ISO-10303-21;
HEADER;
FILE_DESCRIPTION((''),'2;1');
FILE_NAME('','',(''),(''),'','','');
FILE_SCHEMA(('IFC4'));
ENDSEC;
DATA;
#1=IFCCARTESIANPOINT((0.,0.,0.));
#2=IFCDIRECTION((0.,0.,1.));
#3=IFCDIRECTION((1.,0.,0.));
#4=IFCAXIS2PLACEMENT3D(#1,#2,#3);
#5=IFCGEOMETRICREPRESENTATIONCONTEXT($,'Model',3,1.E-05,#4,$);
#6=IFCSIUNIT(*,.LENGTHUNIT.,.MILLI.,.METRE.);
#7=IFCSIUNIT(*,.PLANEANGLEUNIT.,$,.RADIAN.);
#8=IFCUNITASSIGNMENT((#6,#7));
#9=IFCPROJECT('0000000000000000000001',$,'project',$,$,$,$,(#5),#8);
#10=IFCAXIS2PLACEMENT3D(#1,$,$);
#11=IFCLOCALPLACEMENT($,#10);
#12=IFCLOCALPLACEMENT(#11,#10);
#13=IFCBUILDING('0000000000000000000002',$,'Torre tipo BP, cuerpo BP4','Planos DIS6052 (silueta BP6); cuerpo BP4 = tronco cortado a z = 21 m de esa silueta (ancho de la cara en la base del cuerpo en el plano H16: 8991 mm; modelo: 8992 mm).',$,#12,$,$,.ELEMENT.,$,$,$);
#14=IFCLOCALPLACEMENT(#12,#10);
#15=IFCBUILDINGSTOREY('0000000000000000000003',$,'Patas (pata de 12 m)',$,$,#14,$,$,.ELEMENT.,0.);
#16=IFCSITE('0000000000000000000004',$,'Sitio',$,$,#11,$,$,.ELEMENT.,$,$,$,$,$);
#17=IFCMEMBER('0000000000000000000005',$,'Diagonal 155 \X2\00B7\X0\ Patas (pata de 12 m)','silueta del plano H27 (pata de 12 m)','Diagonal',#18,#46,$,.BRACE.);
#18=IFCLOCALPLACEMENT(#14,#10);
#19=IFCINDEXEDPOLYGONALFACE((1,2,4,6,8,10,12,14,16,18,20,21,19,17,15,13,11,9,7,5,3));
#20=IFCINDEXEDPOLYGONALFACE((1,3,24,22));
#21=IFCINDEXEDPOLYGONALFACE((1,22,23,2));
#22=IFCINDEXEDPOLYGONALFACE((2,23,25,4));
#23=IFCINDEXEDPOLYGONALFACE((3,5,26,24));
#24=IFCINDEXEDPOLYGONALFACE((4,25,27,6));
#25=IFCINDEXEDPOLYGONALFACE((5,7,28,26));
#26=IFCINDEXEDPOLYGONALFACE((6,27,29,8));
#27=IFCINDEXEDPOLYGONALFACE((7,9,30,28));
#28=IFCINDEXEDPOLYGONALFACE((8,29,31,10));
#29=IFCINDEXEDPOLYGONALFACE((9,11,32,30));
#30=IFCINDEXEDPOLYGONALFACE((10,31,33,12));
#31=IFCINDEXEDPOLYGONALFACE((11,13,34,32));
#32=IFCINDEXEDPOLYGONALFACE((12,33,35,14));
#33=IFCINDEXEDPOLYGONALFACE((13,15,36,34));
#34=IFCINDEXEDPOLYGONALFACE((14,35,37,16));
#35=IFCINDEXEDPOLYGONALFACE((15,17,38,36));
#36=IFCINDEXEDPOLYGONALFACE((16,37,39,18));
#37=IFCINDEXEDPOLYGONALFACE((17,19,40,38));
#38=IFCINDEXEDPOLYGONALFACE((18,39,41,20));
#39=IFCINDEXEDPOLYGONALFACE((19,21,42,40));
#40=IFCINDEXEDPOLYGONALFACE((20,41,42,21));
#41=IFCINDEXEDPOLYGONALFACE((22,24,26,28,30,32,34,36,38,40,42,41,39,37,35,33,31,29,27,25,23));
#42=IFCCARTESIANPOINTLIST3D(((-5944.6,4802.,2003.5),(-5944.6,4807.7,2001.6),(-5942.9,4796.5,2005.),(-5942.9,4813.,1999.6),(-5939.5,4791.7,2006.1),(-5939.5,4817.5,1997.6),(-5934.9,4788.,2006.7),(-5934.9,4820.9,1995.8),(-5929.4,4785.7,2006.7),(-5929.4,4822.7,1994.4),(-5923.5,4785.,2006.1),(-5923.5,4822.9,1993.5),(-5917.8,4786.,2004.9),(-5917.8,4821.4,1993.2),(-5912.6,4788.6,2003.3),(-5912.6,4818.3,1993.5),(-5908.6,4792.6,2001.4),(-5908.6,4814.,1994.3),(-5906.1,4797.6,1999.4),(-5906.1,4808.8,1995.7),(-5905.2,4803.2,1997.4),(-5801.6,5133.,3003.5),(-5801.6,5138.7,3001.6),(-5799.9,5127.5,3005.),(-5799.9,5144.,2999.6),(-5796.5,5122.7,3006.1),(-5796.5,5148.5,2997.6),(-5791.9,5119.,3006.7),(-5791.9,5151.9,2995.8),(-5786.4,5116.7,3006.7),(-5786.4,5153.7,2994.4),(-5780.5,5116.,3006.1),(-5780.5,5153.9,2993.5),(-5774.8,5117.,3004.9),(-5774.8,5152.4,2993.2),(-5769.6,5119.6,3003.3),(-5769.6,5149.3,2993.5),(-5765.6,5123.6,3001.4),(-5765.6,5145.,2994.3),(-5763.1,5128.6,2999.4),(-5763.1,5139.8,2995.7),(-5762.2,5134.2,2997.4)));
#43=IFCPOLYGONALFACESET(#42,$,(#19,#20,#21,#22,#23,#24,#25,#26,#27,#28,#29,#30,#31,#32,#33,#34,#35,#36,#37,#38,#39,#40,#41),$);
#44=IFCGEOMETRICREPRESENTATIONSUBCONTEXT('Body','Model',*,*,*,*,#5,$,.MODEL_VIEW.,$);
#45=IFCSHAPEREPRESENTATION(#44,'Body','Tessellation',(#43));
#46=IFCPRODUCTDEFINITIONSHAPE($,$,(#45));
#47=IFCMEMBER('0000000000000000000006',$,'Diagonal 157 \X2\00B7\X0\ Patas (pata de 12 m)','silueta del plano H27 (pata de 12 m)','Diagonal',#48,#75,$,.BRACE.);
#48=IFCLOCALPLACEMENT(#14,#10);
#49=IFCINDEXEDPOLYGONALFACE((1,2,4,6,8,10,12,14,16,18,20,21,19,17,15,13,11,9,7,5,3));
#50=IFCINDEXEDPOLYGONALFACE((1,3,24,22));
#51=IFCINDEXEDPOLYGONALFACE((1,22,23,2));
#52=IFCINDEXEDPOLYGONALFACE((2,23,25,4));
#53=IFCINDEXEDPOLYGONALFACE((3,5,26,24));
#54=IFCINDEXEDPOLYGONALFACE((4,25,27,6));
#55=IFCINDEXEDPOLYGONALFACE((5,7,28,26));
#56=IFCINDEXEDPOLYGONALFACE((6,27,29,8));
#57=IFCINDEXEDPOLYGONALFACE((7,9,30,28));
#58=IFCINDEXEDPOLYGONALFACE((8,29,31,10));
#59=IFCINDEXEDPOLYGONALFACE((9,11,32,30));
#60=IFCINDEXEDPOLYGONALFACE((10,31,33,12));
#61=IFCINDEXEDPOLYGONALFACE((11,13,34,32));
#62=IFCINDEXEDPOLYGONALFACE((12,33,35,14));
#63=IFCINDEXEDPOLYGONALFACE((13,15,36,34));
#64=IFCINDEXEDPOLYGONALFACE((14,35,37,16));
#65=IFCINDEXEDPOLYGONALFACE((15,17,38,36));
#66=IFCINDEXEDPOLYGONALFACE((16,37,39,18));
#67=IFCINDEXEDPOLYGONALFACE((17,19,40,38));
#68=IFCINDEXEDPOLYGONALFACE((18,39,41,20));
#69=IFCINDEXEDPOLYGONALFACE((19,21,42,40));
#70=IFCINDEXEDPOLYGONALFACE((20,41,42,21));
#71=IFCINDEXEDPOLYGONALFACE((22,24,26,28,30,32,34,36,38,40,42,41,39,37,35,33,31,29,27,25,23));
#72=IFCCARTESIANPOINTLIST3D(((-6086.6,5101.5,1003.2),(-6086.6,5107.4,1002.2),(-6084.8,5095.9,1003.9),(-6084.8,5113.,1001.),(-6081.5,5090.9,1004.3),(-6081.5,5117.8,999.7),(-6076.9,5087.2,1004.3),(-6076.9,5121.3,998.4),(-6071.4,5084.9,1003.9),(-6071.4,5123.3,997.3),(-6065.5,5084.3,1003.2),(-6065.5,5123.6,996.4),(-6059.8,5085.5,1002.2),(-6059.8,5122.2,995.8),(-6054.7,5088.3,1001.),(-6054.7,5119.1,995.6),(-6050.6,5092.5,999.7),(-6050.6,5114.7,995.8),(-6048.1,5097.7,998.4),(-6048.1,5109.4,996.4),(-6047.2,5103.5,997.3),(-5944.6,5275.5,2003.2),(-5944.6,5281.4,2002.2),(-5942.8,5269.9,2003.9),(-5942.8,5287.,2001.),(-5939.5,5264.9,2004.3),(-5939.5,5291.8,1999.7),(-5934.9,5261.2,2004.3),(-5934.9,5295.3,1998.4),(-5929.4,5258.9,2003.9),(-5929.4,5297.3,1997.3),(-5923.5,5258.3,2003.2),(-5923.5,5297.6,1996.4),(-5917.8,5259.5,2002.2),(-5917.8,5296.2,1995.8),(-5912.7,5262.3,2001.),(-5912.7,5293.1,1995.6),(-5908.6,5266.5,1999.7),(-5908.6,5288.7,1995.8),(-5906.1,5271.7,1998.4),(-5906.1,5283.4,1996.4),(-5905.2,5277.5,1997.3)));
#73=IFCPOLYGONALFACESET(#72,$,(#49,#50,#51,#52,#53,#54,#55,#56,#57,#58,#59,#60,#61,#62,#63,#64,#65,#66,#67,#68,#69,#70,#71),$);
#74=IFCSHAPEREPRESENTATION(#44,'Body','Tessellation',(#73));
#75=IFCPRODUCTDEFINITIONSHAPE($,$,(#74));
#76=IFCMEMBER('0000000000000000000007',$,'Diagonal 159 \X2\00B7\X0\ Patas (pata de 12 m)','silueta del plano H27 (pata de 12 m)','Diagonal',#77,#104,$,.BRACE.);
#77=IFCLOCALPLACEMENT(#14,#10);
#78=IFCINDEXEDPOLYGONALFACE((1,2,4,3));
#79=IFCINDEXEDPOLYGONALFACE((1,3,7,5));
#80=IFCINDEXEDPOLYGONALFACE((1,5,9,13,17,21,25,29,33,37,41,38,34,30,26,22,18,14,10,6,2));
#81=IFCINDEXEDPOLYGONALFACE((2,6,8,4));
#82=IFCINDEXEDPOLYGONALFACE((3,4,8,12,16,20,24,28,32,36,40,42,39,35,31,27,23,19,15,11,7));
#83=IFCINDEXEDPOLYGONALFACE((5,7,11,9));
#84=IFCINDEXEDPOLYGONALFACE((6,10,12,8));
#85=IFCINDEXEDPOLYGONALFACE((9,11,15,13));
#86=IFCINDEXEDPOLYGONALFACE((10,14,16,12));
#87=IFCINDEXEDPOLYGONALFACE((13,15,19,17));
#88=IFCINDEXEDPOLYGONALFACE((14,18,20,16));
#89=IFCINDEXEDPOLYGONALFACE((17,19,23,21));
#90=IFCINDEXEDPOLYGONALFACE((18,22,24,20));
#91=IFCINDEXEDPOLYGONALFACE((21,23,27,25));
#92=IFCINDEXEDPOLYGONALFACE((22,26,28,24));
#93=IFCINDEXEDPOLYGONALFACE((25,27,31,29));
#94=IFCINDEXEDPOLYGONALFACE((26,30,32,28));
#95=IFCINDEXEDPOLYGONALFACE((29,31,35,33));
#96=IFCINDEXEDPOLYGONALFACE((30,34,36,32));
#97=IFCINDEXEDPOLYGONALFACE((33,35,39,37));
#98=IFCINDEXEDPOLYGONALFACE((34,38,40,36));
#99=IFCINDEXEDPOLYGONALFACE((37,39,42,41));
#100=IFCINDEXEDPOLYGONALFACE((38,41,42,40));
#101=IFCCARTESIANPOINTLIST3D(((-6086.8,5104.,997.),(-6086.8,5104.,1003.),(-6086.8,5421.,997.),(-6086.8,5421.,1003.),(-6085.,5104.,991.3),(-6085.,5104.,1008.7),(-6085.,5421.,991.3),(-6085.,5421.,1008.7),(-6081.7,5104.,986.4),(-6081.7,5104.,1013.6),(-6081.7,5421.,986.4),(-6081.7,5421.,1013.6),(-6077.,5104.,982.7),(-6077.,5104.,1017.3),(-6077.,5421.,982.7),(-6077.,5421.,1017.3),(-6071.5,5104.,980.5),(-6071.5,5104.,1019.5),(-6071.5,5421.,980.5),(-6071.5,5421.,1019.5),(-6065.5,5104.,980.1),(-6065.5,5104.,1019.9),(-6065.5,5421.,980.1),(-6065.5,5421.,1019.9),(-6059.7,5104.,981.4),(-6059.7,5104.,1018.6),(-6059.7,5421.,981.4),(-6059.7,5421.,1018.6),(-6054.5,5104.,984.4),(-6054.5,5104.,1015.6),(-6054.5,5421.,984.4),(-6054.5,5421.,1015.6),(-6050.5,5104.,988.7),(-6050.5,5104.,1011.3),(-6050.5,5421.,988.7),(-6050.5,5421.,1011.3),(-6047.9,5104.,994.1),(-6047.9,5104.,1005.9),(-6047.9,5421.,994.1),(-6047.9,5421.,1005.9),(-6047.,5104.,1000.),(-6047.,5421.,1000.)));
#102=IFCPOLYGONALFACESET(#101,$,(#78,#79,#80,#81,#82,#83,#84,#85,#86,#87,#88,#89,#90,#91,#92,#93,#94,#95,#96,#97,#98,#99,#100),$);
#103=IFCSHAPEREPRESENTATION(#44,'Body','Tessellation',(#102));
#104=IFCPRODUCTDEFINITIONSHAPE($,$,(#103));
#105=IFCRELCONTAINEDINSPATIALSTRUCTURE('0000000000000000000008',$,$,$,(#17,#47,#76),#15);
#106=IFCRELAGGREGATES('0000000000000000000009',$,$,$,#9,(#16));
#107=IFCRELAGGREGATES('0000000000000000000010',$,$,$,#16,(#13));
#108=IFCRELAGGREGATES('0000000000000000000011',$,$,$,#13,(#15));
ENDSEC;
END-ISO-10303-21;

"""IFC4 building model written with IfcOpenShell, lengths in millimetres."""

from ifc_helpers import new_model, si_unit, frame, origin, origin_with_axes, place, context, subcontext, project, spatial, circle, extrude, element, save


model = new_model("IFC4")

# Units and contexts
model_context = context("Model", 3, precision=1e-05, world=origin_with_axes())
body_context = subcontext(model_context, "Body", "Model", "MODEL_VIEW")
ifc_project = project(units=[si_unit("LENGTHUNIT", "METRE", prefix="MILLI"), si_unit("PLANEANGLEUNIT", "RADIAN")], contexts=[model_context])

# Site, building, storey
site_placement = place(None, origin())
site = spatial("IfcSite", under=ifc_project, at=site_placement, Name="Sitio", CompositionType="ELEMENT")
building_placement = place(site_placement, origin())
building = spatial("IfcBuilding", under=site, at=building_placement, Name="Torre tipo BP, cuerpo BP4", Description="Planos DIS6052 (silueta BP6); cuerpo BP4 = tronco cortado a z = 21 m de esa silueta (ancho de la cara en la base del cuerpo en el plano H16: 8991 mm; modelo: 8992 mm).", CompositionType="ELEMENT")
storey_placement = place(building_placement, origin())
storey = spatial("IfcBuildingStorey", under=building, at=storey_placement, Name="Patas (pata de 12 m)", CompositionType="ELEMENT", Elevation=0.0)

# Members
member_1_placement = place(storey_placement, frame((-5925.0, 4804.0, 2000.0), z_axis=(0.134522, 0.311377, 0.940717), x_axis=(0.990911, -0.042271, -0.127708)))
element("IfcMember", 1, at=member_1_placement, inside=storey, Name="Diagonal 155 · Patas (pata de 12 m)", Description="silueta del plano H27 (pata de 12 m)", ObjectType="Diagonal", PredefinedType="BRACE", context=body_context, shape_type="SweptSolid", body=[
    extrude(circle(Radius=20.0), None, (0.0, 0.0, 1.0), 1063.0),
])
member_2_placement = place(storey_placement, frame((-6067.0, 5104.0, 1000.0), z_axis=(0.138549, 0.169771, 0.975696), x_axis=(0.990356, -0.023751, -0.136498)))
element("IfcMember", 2, at=member_2_placement, inside=storey, Name="Diagonal 157 · Patas (pata de 12 m)", Description="silueta del plano H27 (pata de 12 m)", ObjectType="Diagonal", PredefinedType="BRACE", context=body_context, shape_type="SweptSolid", body=[
    extrude(circle(Radius=20.0), None, (0.0, 0.0, 1.0), 1024.9),
])
member_3_placement = place(storey_placement, frame((-6067.0, 5421.0, 1000.0), z_axis=(0.0, -1.0, 0.0), x_axis=(1.0, 0.0, 0.0)))
element("IfcMember", 3, at=member_3_placement, inside=storey, Name="Diagonal 159 · Patas (pata de 12 m)", Description="silueta del plano H27 (pata de 12 m)", ObjectType="Diagonal", PredefinedType="BRACE", context=body_context, shape_type="SweptSolid", body=[
    extrude(circle(Radius=20.0), None, (0.0, 0.0, 1.0), 317.0),
])

save(model, "model.ifc")
